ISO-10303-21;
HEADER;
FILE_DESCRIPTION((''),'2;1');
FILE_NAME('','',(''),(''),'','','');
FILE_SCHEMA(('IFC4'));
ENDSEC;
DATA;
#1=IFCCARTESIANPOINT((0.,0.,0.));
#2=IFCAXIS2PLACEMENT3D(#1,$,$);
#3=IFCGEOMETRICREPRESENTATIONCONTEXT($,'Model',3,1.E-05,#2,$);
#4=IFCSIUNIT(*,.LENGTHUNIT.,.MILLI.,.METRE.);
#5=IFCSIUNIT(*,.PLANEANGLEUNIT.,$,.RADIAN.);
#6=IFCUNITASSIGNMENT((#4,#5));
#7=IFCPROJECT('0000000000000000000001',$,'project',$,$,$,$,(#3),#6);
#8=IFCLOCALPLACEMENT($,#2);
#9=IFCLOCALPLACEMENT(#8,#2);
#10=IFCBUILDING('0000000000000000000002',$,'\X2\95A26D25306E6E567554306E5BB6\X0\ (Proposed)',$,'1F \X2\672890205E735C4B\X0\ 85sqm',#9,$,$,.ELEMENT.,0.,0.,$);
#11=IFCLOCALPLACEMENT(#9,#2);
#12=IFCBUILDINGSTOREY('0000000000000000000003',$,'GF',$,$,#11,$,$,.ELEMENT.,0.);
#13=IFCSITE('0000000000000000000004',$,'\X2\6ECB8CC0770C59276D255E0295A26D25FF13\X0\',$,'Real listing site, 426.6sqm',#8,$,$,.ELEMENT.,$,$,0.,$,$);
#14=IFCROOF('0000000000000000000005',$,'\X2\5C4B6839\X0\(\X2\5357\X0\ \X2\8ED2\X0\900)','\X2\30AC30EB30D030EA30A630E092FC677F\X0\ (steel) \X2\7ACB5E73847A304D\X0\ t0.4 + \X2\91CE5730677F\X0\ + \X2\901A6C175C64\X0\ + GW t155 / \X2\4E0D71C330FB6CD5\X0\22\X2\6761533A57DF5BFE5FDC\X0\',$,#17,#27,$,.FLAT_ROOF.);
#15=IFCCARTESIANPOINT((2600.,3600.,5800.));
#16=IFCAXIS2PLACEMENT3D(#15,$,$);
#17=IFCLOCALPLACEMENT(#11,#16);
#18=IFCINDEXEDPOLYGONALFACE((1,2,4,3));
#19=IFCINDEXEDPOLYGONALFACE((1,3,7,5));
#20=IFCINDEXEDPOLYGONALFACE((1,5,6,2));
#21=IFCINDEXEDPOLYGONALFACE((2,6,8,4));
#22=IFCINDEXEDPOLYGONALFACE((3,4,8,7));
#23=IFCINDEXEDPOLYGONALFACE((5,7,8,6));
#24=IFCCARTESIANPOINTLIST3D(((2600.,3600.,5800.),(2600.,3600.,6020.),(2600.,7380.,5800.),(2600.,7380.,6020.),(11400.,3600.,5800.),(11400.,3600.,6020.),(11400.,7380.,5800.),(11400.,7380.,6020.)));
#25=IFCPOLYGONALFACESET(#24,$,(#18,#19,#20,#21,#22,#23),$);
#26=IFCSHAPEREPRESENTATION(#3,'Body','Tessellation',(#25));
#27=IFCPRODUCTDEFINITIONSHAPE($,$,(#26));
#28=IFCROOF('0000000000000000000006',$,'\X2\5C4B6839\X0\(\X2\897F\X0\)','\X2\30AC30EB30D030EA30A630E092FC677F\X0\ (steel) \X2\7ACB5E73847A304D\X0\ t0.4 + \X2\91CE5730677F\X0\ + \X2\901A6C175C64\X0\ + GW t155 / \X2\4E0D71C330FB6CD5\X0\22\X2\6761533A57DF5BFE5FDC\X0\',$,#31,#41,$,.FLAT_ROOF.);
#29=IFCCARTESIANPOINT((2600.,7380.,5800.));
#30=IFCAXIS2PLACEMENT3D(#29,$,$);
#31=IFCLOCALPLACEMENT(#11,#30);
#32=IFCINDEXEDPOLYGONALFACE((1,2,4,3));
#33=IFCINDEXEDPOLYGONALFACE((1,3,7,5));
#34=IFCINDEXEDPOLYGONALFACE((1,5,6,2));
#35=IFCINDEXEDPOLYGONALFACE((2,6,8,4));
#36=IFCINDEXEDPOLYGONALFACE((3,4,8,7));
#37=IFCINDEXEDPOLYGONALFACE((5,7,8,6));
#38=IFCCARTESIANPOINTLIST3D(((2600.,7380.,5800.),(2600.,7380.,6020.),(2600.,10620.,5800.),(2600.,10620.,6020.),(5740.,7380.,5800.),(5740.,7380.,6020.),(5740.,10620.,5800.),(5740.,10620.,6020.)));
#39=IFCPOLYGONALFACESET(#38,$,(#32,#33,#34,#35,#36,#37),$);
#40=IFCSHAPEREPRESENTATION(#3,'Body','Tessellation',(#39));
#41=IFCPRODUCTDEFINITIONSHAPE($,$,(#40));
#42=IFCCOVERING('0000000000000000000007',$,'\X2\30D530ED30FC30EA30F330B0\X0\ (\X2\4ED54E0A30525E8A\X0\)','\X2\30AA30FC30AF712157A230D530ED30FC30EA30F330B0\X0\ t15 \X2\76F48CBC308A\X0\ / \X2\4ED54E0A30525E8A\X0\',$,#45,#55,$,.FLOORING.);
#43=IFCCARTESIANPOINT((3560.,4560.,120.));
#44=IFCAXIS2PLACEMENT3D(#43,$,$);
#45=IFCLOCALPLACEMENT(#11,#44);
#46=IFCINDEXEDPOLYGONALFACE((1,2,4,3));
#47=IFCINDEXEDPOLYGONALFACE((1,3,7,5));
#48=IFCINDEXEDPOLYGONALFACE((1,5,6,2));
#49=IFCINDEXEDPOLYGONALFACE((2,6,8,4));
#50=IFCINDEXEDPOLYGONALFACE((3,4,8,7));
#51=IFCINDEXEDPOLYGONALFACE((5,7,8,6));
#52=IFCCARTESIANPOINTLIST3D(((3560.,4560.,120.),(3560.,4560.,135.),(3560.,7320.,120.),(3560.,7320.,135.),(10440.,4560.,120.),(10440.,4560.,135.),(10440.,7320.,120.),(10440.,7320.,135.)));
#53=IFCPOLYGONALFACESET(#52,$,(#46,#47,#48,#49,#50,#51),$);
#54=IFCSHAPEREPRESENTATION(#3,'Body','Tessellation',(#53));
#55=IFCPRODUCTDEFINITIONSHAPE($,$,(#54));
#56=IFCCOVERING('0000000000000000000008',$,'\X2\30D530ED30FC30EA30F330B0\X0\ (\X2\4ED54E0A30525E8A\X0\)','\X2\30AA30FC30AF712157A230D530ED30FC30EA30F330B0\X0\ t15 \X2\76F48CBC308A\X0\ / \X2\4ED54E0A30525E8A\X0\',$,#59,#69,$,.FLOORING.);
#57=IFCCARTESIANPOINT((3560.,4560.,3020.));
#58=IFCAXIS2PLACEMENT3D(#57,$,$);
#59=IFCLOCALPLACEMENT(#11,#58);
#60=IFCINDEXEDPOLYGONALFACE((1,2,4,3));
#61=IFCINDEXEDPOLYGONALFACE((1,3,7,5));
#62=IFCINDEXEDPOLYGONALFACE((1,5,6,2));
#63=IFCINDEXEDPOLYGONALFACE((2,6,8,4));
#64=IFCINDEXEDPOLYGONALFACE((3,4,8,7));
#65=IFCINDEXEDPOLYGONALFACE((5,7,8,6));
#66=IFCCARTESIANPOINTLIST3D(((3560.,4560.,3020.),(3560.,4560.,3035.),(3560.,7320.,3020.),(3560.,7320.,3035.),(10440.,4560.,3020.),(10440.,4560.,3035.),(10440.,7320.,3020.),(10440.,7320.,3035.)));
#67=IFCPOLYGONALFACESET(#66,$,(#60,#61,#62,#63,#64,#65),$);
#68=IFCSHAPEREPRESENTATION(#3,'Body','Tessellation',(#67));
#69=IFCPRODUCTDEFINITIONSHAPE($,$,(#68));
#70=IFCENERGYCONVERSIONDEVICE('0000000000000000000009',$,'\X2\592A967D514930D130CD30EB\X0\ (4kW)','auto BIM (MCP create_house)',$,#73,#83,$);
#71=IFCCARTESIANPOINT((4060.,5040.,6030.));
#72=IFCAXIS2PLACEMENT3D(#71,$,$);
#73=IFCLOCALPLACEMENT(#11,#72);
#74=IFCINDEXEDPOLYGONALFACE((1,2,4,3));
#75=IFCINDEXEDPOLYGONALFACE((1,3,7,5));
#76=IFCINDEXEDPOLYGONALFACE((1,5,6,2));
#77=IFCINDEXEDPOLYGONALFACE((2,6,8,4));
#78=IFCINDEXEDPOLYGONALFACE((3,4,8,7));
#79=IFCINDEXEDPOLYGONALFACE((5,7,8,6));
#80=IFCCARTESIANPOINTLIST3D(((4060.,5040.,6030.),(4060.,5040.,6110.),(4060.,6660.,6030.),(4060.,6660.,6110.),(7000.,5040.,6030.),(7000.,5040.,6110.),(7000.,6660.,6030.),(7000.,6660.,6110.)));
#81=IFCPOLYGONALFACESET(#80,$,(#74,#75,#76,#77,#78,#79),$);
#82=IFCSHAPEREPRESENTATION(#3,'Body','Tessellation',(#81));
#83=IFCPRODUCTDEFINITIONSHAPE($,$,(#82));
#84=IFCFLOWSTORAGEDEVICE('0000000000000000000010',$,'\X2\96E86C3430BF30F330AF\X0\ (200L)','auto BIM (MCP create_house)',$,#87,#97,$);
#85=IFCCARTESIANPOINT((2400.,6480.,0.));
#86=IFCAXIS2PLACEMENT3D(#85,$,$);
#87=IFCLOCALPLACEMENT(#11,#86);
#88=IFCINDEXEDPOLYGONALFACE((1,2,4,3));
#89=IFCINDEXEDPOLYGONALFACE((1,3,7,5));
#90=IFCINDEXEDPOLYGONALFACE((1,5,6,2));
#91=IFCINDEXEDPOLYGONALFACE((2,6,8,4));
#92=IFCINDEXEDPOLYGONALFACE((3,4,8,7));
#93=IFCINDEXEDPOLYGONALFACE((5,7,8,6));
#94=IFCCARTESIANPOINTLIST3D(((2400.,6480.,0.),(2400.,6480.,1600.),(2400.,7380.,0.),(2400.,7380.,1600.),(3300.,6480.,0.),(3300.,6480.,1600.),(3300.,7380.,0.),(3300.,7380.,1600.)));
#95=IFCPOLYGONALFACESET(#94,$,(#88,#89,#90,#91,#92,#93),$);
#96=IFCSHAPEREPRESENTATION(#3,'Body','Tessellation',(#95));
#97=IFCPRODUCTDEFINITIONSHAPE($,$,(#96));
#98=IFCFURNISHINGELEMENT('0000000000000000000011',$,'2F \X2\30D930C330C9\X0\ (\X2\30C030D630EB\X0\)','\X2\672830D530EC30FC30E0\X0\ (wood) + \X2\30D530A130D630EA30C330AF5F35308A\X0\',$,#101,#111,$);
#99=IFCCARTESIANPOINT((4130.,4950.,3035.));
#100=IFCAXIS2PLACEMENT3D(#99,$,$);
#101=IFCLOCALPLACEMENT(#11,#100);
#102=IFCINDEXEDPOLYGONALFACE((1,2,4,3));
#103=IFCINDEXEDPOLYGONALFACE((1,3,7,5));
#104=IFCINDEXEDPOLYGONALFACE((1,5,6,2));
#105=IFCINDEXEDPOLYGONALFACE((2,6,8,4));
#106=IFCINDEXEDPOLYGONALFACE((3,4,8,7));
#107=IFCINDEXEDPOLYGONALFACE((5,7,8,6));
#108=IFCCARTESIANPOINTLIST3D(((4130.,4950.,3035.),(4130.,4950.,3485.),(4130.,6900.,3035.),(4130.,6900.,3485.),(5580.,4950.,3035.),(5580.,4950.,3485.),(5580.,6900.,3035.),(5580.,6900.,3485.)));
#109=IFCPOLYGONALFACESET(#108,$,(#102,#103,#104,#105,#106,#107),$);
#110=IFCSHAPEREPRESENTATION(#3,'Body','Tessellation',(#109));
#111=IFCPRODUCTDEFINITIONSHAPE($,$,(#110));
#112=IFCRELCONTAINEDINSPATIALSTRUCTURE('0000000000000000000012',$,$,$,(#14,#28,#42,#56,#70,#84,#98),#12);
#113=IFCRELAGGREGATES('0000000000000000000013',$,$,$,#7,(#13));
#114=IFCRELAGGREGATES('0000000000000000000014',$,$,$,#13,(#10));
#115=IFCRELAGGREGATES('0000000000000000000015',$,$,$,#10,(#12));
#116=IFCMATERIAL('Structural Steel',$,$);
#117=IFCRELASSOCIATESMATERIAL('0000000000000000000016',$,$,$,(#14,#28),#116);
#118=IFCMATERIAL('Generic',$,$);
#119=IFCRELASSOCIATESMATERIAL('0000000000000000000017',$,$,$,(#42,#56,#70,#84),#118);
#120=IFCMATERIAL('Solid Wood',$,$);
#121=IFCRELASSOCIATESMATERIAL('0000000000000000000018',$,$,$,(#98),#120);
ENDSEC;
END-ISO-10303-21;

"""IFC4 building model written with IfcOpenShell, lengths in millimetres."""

from ifc_helpers import new_model, si_unit, frame, frame_2d, origin, place, context, project, spatial, rectangle, extrude, material, element, save


model = new_model("IFC4")

# Units and contexts
model_context = context("Model", 3, precision=1e-05, world=origin())
ifc_project = project(units=[si_unit("LENGTHUNIT", "METRE", prefix="MILLI"), si_unit("PLANEANGLEUNIT", "RADIAN")], contexts=[model_context])

# Site, building, storey
site_placement = place(None, origin())
site = spatial("IfcSite", under=ifc_project, at=site_placement, Name="滋賀県大津市関津３", ObjectType="Real listing site, 426.6sqm", CompositionType="ELEMENT", RefElevation=0.0)
building_placement = place(site_placement, origin())
building = spatial("IfcBuilding", under=site, at=building_placement, Name="関津の湖畔の家 (Proposed)", ObjectType="1F 木造平屋 85sqm", CompositionType="ELEMENT", ElevationOfRefHeight=0.0, ElevationOfTerrain=0.0)
storey_placement = place(building_placement, origin())
storey = spatial("IfcBuildingStorey", under=building, at=storey_placement, Name="GF", CompositionType="ELEMENT", Elevation=0.0)

# Shared definitions
ifc_material_1 = material(Name="Solid Wood")
ifc_material_2 = material(Name="Generic")

# Roofs
ifc_material_3 = material(Name="Structural Steel")
roof_1_placement = place(storey_placement, frame((2600.0, 3600.0, 5800.0)))
element("IfcRoof", 1, at=roof_1_placement, inside=storey, material=ifc_material_3, Name="屋根(南 軒900)", Description="ガルバリウム鋼板 (steel) 立平葺き t0.4 + 野地板 + 通気層 + GW t155 / 不燃・法22条区域対応", PredefinedType="FLAT_ROOF", context=model_context, shape_type="SweptSolid", body=[
    extrude(rectangle(XDim=8800.0, YDim=3780.0, at=frame_2d((4400.0, 1890.0))), frame((2600.0, 3600.0, 5800.0)), (0.0, 0.0, 1.0), 220.0),
])
roof_2_placement = place(storey_placement, frame((2600.0, 7380.0, 5800.0)))
element("IfcRoof", 2, at=roof_2_placement, inside=storey, material=ifc_material_3, Name="屋根(西)", Description="ガルバリウム鋼板 (steel) 立平葺き t0.4 + 野地板 + 通気層 + GW t155 / 不燃・法22条区域対応", PredefinedType="FLAT_ROOF", context=model_context, shape_type="SweptSolid", body=[
    extrude(rectangle(XDim=3140.0, YDim=3240.0, at=frame_2d((1570.0, 1620.0))), frame((2600.0, 7380.0, 5800.0)), (0.0, 0.0, 1.0), 220.0),
])

# Coverings
covering_1_placement = place(storey_placement, frame((3560.0, 4560.0, 120.0)))
element("IfcCovering", 3, at=covering_1_placement, inside=storey, material=ifc_material_2, Name="フローリング (仕上げ床)", Description="オーク無垢フローリング t15 直貼り / 仕上げ床", PredefinedType="FLOORING", context=model_context, shape_type="SweptSolid", body=[
    extrude(rectangle(XDim=6880.0, YDim=2760.0, at=frame_2d((3440.0, 1380.0))), frame((3560.0, 4560.0, 120.0)), (0.0, 0.0, 1.0), 15.0),
])
covering_2_placement = place(storey_placement, frame((3560.0, 4560.0, 3020.0)))
element("IfcCovering", 4, at=covering_2_placement, inside=storey, material=ifc_material_2, Name="フローリング (仕上げ床)", Description="オーク無垢フローリング t15 直貼り / 仕上げ床", PredefinedType="FLOORING", context=model_context, shape_type="SweptSolid", body=[
    extrude(rectangle(XDim=6880.0, YDim=2760.0, at=frame_2d((3440.0, 1380.0))), frame((3560.0, 4560.0, 3020.0)), (0.0, 0.0, 1.0), 15.0),
])

# Energy conversion device
energy_conversion_device_placement = place(storey_placement, frame((4060.0, 5040.0, 6030.0)))
element("IfcEnergyConversionDevice", 5, at=energy_conversion_device_placement, inside=storey, material=ifc_material_2, Name="太陽光パネル (4kW)", Description="auto BIM (MCP create_house)", context=model_context, shape_type="SweptSolid", body=[
    extrude(rectangle(XDim=2940.0, YDim=1620.0, at=frame_2d((1470.0, 810.0))), frame((4060.0, 5040.0, 6030.0)), (0.0, 0.0, 1.0), 80.0),
])

# Flow storage device
flow_storage_device_placement = place(storey_placement, frame((2400.0, 6480.0, 0.0)))
element("IfcFlowStorageDevice", 6, at=flow_storage_device_placement, inside=storey, material=ifc_material_2, Name="雨水タンク (200L)", Description="auto BIM (MCP create_house)", context=model_context, shape_type="SweptSolid", body=[
    extrude(rectangle(XDim=900.0, YDim=900.0, at=frame_2d((450.0, 450.0))), frame((2400.0, 6480.0, 0.0)), (0.0, 0.0, 1.0), 1600.0),
])

# Furnishing element
furnishing_placement = place(storey_placement, frame((4130.0, 4950.0, 3035.0)))
element("IfcFurnishingElement", 7, at=furnishing_placement, inside=storey, material=ifc_material_1, Name="2F ベッド (ダブル)", Description="木フレーム (wood) + ファブリック張り", context=model_context, shape_type="SweptSolid", body=[
    extrude(rectangle(XDim=1450.0, YDim=1950.0, at=frame_2d((725.0, 975.0))), frame((4130.0, 4950.0, 3035.0)), (0.0, 0.0, 1.0), 450.0),
])

save(model, "model.ifc")
